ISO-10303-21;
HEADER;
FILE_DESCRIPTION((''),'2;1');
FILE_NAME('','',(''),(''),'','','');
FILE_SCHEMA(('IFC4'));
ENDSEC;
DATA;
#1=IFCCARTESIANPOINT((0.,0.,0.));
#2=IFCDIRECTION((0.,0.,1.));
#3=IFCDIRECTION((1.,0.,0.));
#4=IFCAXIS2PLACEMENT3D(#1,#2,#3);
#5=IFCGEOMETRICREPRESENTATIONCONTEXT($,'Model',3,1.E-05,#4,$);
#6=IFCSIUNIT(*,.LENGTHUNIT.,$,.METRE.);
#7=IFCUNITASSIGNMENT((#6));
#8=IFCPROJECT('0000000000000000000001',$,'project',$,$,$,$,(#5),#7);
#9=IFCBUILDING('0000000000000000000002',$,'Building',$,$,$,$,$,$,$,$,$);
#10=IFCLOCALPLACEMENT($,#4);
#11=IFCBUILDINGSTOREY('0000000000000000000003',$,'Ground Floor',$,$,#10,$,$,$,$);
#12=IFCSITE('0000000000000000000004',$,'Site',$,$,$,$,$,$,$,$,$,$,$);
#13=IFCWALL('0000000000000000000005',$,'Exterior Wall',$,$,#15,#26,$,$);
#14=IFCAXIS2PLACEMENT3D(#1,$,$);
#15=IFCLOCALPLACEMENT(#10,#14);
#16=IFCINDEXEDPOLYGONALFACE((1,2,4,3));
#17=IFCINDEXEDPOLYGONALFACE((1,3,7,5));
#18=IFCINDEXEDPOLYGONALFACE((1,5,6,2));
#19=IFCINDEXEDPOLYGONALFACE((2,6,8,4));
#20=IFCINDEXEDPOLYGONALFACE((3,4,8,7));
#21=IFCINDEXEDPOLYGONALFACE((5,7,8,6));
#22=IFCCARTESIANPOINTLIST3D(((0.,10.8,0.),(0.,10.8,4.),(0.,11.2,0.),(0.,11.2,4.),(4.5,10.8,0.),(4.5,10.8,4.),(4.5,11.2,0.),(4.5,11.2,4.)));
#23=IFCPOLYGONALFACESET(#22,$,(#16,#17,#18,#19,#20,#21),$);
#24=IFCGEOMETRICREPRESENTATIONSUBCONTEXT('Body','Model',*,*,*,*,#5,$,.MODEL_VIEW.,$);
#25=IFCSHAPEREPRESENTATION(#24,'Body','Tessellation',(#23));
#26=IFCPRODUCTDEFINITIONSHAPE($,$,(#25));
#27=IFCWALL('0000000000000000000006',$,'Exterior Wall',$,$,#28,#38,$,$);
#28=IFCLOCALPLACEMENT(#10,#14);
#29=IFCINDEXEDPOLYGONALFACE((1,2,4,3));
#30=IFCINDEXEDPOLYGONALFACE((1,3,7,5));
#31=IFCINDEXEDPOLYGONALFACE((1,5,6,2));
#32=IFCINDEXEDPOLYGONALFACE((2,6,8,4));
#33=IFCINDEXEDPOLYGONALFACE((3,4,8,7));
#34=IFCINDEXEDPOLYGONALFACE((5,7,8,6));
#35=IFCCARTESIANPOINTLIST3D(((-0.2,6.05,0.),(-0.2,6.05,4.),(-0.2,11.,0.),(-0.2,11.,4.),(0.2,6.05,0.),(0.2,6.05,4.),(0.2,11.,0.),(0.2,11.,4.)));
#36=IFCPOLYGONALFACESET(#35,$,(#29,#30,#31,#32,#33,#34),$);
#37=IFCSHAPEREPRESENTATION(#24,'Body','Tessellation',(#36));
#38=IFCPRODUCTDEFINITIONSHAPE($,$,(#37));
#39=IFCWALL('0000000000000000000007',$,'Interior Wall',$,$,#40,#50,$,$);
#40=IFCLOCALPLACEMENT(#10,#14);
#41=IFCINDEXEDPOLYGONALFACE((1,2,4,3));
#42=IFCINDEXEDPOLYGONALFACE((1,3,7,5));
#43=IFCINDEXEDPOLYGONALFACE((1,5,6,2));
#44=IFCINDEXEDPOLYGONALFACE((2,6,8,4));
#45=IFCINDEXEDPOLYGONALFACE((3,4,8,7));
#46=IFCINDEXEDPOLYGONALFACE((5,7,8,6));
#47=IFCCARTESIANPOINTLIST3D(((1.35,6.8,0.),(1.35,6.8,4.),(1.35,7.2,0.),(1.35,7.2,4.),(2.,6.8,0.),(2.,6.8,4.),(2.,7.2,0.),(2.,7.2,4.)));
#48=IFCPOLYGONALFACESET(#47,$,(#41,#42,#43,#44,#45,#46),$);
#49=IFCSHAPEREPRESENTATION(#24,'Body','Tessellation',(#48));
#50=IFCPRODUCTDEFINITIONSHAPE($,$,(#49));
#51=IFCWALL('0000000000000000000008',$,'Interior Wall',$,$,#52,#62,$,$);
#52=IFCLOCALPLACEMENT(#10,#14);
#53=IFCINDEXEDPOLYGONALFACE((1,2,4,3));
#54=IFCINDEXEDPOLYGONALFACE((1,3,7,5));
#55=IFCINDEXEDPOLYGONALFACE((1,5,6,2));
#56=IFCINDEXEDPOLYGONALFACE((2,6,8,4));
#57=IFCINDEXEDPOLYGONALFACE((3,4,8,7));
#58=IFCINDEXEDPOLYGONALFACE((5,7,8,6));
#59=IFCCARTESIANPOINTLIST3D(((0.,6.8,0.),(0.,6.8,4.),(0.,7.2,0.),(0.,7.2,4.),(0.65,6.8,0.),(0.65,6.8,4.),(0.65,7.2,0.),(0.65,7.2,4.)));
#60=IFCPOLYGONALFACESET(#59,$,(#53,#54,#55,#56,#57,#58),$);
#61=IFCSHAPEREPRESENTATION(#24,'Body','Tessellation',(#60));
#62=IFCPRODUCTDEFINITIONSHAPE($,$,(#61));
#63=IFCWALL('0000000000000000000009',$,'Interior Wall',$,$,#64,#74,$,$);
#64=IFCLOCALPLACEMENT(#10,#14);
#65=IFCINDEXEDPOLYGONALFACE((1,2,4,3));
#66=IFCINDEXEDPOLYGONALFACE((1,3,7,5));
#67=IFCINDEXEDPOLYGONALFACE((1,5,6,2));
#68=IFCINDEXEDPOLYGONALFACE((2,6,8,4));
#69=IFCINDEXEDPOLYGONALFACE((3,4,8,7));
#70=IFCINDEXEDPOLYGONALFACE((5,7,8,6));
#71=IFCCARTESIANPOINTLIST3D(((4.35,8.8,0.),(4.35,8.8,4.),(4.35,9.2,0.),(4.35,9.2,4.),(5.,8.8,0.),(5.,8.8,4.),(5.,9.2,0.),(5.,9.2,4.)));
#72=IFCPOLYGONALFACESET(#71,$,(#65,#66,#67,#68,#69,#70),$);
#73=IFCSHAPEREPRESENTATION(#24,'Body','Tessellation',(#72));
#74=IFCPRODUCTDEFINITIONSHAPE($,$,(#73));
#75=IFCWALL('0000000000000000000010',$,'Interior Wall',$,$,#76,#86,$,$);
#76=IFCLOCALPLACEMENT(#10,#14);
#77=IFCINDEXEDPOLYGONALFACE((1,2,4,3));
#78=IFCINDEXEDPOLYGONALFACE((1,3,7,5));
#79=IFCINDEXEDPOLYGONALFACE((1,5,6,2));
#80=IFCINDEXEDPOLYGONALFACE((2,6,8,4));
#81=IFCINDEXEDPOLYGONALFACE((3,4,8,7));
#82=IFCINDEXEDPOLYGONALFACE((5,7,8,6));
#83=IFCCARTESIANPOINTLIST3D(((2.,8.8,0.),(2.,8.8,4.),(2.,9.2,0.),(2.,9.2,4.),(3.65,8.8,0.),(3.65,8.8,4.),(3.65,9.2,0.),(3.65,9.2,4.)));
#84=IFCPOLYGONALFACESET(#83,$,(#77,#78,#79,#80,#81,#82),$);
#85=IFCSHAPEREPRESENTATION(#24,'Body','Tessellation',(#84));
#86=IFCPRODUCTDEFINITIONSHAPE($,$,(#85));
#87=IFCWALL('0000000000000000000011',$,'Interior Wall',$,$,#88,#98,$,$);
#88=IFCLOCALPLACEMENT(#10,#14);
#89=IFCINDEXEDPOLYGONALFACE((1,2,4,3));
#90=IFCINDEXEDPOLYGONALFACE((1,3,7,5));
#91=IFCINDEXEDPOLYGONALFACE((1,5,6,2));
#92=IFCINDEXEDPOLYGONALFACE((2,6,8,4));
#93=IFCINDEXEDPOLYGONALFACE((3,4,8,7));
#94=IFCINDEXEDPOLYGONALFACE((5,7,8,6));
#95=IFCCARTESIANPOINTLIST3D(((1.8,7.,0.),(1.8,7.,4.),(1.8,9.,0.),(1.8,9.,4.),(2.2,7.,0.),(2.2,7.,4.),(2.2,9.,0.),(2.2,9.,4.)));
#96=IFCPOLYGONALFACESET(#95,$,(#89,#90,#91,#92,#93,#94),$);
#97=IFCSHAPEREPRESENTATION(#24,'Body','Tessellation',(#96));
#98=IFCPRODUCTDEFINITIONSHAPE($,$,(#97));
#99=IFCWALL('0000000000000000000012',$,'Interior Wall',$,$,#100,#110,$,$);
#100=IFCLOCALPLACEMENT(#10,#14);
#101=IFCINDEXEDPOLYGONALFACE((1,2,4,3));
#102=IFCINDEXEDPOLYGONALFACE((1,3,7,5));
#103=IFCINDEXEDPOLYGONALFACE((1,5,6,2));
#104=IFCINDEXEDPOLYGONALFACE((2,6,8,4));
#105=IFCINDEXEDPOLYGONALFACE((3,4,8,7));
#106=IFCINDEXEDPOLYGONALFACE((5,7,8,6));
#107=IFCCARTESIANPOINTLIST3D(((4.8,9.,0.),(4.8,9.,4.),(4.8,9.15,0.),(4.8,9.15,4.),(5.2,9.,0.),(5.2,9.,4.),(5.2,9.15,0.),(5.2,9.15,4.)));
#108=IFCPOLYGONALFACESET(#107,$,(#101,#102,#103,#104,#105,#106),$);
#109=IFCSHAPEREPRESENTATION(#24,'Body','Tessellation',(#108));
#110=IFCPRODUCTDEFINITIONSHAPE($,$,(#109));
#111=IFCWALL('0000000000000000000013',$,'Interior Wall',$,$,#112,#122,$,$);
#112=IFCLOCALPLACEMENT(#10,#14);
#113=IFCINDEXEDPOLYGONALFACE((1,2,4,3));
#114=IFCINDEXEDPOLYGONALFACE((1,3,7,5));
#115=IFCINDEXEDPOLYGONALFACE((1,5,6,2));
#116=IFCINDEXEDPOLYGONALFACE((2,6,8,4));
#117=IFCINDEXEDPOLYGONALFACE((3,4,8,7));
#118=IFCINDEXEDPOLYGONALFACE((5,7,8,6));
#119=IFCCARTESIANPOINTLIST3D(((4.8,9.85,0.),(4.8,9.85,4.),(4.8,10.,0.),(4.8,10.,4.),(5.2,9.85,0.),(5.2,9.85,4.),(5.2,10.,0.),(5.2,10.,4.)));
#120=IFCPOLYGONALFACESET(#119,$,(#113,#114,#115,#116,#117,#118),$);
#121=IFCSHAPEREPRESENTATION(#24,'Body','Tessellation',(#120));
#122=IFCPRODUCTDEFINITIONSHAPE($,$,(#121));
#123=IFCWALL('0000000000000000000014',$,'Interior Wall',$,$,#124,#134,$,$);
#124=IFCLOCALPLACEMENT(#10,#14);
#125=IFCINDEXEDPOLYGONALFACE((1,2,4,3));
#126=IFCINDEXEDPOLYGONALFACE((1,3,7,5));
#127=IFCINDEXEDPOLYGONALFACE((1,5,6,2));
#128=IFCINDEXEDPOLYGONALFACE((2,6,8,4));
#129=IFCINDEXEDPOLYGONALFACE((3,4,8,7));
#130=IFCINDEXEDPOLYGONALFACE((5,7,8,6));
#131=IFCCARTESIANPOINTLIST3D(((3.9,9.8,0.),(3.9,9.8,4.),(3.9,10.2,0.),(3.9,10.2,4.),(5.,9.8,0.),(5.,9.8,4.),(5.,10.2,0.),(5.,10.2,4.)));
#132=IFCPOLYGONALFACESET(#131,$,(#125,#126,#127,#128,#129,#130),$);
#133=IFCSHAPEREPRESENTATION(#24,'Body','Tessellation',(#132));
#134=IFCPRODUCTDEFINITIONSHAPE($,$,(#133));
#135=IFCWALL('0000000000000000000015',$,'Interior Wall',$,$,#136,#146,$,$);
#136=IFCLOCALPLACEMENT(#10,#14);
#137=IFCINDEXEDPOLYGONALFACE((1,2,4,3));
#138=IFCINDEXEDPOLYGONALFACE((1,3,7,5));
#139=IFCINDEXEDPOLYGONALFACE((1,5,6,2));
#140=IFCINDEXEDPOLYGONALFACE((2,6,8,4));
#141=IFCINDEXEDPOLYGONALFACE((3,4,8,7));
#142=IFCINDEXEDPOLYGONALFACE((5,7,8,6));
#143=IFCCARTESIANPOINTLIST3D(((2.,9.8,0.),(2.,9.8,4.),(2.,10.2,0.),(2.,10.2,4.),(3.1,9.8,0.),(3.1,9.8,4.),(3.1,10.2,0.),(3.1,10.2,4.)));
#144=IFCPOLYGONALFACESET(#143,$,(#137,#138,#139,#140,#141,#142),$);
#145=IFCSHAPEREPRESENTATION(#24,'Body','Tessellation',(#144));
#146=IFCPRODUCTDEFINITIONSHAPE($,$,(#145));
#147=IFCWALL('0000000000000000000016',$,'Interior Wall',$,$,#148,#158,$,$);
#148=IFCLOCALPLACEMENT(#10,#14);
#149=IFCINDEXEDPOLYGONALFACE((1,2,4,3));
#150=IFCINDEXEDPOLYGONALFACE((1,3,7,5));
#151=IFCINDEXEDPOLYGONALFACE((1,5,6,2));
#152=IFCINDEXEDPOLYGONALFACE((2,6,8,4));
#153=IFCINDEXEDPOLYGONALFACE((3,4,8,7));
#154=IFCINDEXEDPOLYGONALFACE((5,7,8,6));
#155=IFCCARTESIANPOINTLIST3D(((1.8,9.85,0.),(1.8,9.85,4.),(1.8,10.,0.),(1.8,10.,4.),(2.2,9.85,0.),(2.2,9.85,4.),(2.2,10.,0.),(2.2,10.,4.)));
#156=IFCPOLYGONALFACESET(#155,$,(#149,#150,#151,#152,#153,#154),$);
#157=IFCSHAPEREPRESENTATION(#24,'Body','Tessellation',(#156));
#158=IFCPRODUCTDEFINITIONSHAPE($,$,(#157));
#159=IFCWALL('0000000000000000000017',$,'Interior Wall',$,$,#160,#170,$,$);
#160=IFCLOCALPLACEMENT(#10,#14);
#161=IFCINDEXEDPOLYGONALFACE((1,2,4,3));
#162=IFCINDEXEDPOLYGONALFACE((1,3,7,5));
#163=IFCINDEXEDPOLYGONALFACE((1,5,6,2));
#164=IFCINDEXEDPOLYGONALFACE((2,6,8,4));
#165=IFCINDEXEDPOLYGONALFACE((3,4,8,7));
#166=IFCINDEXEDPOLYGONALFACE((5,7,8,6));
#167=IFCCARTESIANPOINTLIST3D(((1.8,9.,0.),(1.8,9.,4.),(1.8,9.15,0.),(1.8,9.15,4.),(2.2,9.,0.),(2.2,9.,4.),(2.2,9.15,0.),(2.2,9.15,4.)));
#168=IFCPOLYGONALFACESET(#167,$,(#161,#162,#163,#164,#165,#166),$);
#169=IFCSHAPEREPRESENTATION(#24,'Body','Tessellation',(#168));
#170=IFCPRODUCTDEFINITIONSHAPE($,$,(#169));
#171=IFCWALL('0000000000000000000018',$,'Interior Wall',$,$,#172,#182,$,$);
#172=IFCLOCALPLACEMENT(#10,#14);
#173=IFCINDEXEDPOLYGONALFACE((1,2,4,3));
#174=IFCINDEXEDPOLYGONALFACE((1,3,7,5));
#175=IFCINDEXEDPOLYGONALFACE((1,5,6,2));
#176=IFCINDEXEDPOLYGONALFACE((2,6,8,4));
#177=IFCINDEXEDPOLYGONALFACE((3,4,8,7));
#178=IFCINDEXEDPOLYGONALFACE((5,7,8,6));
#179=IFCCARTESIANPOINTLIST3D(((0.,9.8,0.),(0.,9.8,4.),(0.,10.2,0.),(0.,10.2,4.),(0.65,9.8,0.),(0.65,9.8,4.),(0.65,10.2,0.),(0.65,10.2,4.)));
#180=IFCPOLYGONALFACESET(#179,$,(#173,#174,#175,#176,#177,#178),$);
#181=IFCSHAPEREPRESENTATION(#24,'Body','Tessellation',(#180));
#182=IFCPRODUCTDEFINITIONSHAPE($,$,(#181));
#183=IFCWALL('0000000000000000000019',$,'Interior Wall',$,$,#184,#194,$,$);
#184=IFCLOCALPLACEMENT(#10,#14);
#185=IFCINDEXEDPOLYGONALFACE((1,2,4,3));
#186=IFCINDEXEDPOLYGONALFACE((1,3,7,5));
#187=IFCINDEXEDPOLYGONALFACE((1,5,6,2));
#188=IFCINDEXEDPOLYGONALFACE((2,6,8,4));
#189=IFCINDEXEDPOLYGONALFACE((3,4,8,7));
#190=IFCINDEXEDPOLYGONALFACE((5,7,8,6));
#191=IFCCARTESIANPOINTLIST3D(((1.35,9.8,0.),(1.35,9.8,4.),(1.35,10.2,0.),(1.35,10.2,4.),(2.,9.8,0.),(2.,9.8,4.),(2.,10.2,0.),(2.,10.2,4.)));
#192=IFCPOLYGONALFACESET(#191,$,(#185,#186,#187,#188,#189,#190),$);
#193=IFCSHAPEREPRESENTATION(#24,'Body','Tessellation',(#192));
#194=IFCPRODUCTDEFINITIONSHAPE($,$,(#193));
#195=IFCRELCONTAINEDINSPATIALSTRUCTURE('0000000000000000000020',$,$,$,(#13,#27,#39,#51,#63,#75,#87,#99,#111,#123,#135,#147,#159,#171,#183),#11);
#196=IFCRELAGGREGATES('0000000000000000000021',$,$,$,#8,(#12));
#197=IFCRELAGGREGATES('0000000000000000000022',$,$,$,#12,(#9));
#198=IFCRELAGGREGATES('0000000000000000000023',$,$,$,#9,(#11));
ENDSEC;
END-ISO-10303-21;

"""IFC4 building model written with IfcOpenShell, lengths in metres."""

from ifc_helpers import new_model, si_unit, frame, origin_with_axes, place, context, subcontext, project, spatial, indexed_curve, outline, extrude, element, save


model = new_model("IFC4")

# Units and contexts
model_context = context("Model", 3, precision=1e-05, world=origin_with_axes())
body_context = subcontext(model_context, "Body", "Model", "MODEL_VIEW")
ifc_project = project(units=[si_unit("LENGTHUNIT", "METRE")], contexts=[model_context])

# Site, building, storey
site = spatial("IfcSite", under=ifc_project, Name="Site")
building = spatial("IfcBuilding", under=site, Name="Building")
storey_placement = place(None, origin_with_axes())
storey = spatial("IfcBuildingStorey", under=building, at=storey_placement, Name="Ground Floor")

# Walls
wall_1_placement = place(storey_placement, frame((4.5, 11.0, 0.0), z_axis=(0.0, 0.0, 1.0), x_axis=(-1.0, 0.0, 0.0)))
element("IfcWall", 1, at=wall_1_placement, inside=storey, Name="Exterior Wall", context=body_context, shape_type="SweptSolid", body=[
    extrude(outline(indexed_curve([(0.0, 0.0), (0.0, 0.4), (4.5, 0.4), (4.5, 0.0), (0.0, 0.0)], self_intersect=False)), frame((0.0, -0.2, 0.0), z_axis=(0.0, 0.0, 1.0), x_axis=(1.0, 0.0, 0.0)), (0.0, 0.0, 1.0), 4.0),
])
wall_2_placement = place(storey_placement, frame((0.0, 11.0, 0.0), z_axis=(0.0, 0.0, 1.0), x_axis=(0.0, -1.0, 0.0)))
element("IfcWall", 2, at=wall_2_placement, inside=storey, Name="Exterior Wall", context=body_context, shape_type="SweptSolid", body=[
    extrude(outline(indexed_curve([(0.0, 0.0), (0.0, 0.4), (4.95, 0.4), (4.95, 0.0), (0.0, 0.0)], self_intersect=False)), frame((0.0, -0.2, 0.0), z_axis=(0.0, 0.0, 1.0), x_axis=(1.0, 0.0, 0.0)), (0.0, 0.0, 1.0), 4.0),
])
for number, where, z_axis, x_axis, name in (
    (3, (2.0, 7.0, 0.0), (0.0, 0.0, 1.0), (-1.0, 0.0, 0.0), "Interior Wall"),
    (4, (0.65, 7.0, 0.0), (0.0, 0.0, 1.0), (-1.0, 0.0, 0.0), "Interior Wall"),
):
    element("IfcWall", number, at=place(storey_placement, frame(where, z_axis=z_axis, x_axis=x_axis)), inside=storey, Name=name, context=body_context, shape_type="SweptSolid", body=[
        extrude(outline(indexed_curve([(0.0, 0.0), (0.0, 0.4), (0.65, 0.4), (0.65, 0.0), (0.0, 0.0)], self_intersect=False)), frame((0.0, -0.2, 0.0), z_axis=(0.0, 0.0, 1.0), x_axis=(1.0, 0.0, 0.0)), (0.0, 0.0, 1.0), 4.0),
    ])
wall_3_placement = place(storey_placement, frame((5.0, 9.0, 0.0), z_axis=(0.0, 0.0, 1.0), x_axis=(-1.0, 0.0, 0.0)))
element("IfcWall", 5, at=wall_3_placement, inside=storey, Name="Interior Wall", context=body_context, shape_type="SweptSolid", body=[
    extrude(outline(indexed_curve([(0.0, 0.0), (0.0, 0.4), (0.65, 0.4), (0.65, 0.0), (0.0, 0.0)], self_intersect=False)), frame((0.0, -0.2, 0.0), z_axis=(0.0, 0.0, 1.0), x_axis=(1.0, 0.0, 0.0)), (0.0, 0.0, 1.0), 4.0),
])
wall_4_placement = place(storey_placement, frame((3.65, 9.0, 0.0), z_axis=(0.0, 0.0, 1.0), x_axis=(-1.0, 0.0, 0.0)))
element("IfcWall", 6, at=wall_4_placement, inside=storey, Name="Interior Wall", context=body_context, shape_type="SweptSolid", body=[
    extrude(outline(indexed_curve([(0.0, 0.0), (0.0, 0.4), (1.65, 0.4), (1.65, 0.0), (0.0, 0.0)], self_intersect=False)), frame((0.0, -0.2, 0.0), z_axis=(0.0, 0.0, 1.0), x_axis=(1.0, 0.0, 0.0)), (0.0, 0.0, 1.0), 4.0),
])
wall_5_placement = place(storey_placement, frame((2.0, 9.0, 0.0), z_axis=(0.0, 0.0, 1.0), x_axis=(0.0, -1.0, 0.0)))
element("IfcWall", 7, at=wall_5_placement, inside=storey, Name="Interior Wall", context=body_context, shape_type="SweptSolid", body=[
    extrude(outline(indexed_curve([(0.0, 0.0), (0.0, 0.4), (2.0, 0.4), (2.0, 0.0), (0.0, 0.0)], self_intersect=False)), frame((0.0, -0.2, 0.0), z_axis=(0.0, 0.0, 1.0), x_axis=(1.0, 0.0, 0.0)), (0.0, 0.0, 1.0), 4.0),
])
for number, where, z_axis, x_axis, name in (
    (8, (5.0, 9.0, 0.0), (0.0, 0.0, 1.0), (0.0, 1.0, 0.0), "Interior Wall"),
    (9, (5.0, 9.85, 0.0), (0.0, 0.0, 1.0), (0.0, 1.0, 0.0), "Interior Wall"),
):
    element("IfcWall", number, at=place(storey_placement, frame(where, z_axis=z_axis, x_axis=x_axis)), inside=storey, Name=name, context=body_context, shape_type="SweptSolid", body=[
        extrude(outline(indexed_curve([(0.0, 0.0), (0.0, 0.4), (0.15, 0.4), (0.15, 0.0), (0.0, 0.0)], self_intersect=False)), frame((0.0, -0.2, 0.0), z_axis=(0.0, 0.0, 1.0), x_axis=(1.0, 0.0, 0.0)), (0.0, 0.0, 1.0), 4.0),
    ])
for number, where, z_axis, x_axis, name in (
    (10, (5.0, 10.0, 0.0), (0.0, 0.0, 1.0), (-1.0, 0.0, 0.0), "Interior Wall"),
    (11, (3.1, 10.0, 0.0), (0.0, 0.0, 1.0), (-1.0, 0.0, 0.0), "Interior Wall"),
):
    element("IfcWall", number, at=place(storey_placement, frame(where, z_axis=z_axis, x_axis=x_axis)), inside=storey, Name=name, context=body_context, shape_type="SweptSolid", body=[
        extrude(outline(indexed_curve([(0.0, 0.0), (0.0, 0.4), (1.1, 0.4), (1.1, 0.0), (0.0, 0.0)], self_intersect=False)), frame((0.0, -0.2, 0.0), z_axis=(0.0, 0.0, 1.0), x_axis=(1.0, 0.0, 0.0)), (0.0, 0.0, 1.0), 4.0),
    ])
for number, where, z_axis, x_axis, name in (
    (12, (2.0, 10.0, 0.0), (0.0, 0.0, 1.0), (0.0, -1.0, 0.0), "Interior Wall"),
    (13, (2.0, 9.15, 0.0), (0.0, 0.0, 1.0), (0.0, -1.0, 0.0), "Interior Wall"),
):
    element("IfcWall", number, at=place(storey_placement, frame(where, z_axis=z_axis, x_axis=x_axis)), inside=storey, Name=name, context=body_context, shape_type="SweptSolid", body=[
        extrude(outline(indexed_curve([(0.0, 0.0), (0.0, 0.4), (0.15, 0.4), (0.15, 0.0), (0.0, 0.0)], self_intersect=False)), frame((0.0, -0.2, 0.0), z_axis=(0.0, 0.0, 1.0), x_axis=(1.0, 0.0, 0.0)), (0.0, 0.0, 1.0), 4.0),
    ])
wall_6_placement = place(storey_placement, frame((0.0, 10.0, 0.0), z_axis=(0.0, 0.0, 1.0), x_axis=(1.0, 0.0, 0.0)))
element("IfcWall", 14, at=wall_6_placement, inside=storey, Name="Interior Wall", context=body_context, shape_type="SweptSolid", body=[
    extrude(outline(indexed_curve([(0.0, 0.0), (0.0, 0.4), (0.65, 0.4), (0.65, 0.0), (0.0, 0.0)], self_intersect=False)), frame((0.0, -0.2, 0.0), z_axis=(0.0, 0.0, 1.0), x_axis=(1.0, 0.0, 0.0)), (0.0, 0.0, 1.0), 4.0),
])
wall_7_placement = place(storey_placement, frame((1.35, 10.0, 0.0), z_axis=(0.0, 0.0, 1.0), x_axis=(1.0, 0.0, 0.0)))
element("IfcWall", 15, at=wall_7_placement, inside=storey, Name="Interior Wall", context=body_context, shape_type="SweptSolid", body=[
    extrude(outline(indexed_curve([(0.0, 0.0), (0.0, 0.4), (0.65, 0.4), (0.65, 0.0), (0.0, 0.0)], self_intersect=False)), frame((0.0, -0.2, 0.0), z_axis=(0.0, 0.0, 1.0), x_axis=(1.0, 0.0, 0.0)), (0.0, 0.0, 1.0), 4.0),
])

save(model, "model.ifc")
